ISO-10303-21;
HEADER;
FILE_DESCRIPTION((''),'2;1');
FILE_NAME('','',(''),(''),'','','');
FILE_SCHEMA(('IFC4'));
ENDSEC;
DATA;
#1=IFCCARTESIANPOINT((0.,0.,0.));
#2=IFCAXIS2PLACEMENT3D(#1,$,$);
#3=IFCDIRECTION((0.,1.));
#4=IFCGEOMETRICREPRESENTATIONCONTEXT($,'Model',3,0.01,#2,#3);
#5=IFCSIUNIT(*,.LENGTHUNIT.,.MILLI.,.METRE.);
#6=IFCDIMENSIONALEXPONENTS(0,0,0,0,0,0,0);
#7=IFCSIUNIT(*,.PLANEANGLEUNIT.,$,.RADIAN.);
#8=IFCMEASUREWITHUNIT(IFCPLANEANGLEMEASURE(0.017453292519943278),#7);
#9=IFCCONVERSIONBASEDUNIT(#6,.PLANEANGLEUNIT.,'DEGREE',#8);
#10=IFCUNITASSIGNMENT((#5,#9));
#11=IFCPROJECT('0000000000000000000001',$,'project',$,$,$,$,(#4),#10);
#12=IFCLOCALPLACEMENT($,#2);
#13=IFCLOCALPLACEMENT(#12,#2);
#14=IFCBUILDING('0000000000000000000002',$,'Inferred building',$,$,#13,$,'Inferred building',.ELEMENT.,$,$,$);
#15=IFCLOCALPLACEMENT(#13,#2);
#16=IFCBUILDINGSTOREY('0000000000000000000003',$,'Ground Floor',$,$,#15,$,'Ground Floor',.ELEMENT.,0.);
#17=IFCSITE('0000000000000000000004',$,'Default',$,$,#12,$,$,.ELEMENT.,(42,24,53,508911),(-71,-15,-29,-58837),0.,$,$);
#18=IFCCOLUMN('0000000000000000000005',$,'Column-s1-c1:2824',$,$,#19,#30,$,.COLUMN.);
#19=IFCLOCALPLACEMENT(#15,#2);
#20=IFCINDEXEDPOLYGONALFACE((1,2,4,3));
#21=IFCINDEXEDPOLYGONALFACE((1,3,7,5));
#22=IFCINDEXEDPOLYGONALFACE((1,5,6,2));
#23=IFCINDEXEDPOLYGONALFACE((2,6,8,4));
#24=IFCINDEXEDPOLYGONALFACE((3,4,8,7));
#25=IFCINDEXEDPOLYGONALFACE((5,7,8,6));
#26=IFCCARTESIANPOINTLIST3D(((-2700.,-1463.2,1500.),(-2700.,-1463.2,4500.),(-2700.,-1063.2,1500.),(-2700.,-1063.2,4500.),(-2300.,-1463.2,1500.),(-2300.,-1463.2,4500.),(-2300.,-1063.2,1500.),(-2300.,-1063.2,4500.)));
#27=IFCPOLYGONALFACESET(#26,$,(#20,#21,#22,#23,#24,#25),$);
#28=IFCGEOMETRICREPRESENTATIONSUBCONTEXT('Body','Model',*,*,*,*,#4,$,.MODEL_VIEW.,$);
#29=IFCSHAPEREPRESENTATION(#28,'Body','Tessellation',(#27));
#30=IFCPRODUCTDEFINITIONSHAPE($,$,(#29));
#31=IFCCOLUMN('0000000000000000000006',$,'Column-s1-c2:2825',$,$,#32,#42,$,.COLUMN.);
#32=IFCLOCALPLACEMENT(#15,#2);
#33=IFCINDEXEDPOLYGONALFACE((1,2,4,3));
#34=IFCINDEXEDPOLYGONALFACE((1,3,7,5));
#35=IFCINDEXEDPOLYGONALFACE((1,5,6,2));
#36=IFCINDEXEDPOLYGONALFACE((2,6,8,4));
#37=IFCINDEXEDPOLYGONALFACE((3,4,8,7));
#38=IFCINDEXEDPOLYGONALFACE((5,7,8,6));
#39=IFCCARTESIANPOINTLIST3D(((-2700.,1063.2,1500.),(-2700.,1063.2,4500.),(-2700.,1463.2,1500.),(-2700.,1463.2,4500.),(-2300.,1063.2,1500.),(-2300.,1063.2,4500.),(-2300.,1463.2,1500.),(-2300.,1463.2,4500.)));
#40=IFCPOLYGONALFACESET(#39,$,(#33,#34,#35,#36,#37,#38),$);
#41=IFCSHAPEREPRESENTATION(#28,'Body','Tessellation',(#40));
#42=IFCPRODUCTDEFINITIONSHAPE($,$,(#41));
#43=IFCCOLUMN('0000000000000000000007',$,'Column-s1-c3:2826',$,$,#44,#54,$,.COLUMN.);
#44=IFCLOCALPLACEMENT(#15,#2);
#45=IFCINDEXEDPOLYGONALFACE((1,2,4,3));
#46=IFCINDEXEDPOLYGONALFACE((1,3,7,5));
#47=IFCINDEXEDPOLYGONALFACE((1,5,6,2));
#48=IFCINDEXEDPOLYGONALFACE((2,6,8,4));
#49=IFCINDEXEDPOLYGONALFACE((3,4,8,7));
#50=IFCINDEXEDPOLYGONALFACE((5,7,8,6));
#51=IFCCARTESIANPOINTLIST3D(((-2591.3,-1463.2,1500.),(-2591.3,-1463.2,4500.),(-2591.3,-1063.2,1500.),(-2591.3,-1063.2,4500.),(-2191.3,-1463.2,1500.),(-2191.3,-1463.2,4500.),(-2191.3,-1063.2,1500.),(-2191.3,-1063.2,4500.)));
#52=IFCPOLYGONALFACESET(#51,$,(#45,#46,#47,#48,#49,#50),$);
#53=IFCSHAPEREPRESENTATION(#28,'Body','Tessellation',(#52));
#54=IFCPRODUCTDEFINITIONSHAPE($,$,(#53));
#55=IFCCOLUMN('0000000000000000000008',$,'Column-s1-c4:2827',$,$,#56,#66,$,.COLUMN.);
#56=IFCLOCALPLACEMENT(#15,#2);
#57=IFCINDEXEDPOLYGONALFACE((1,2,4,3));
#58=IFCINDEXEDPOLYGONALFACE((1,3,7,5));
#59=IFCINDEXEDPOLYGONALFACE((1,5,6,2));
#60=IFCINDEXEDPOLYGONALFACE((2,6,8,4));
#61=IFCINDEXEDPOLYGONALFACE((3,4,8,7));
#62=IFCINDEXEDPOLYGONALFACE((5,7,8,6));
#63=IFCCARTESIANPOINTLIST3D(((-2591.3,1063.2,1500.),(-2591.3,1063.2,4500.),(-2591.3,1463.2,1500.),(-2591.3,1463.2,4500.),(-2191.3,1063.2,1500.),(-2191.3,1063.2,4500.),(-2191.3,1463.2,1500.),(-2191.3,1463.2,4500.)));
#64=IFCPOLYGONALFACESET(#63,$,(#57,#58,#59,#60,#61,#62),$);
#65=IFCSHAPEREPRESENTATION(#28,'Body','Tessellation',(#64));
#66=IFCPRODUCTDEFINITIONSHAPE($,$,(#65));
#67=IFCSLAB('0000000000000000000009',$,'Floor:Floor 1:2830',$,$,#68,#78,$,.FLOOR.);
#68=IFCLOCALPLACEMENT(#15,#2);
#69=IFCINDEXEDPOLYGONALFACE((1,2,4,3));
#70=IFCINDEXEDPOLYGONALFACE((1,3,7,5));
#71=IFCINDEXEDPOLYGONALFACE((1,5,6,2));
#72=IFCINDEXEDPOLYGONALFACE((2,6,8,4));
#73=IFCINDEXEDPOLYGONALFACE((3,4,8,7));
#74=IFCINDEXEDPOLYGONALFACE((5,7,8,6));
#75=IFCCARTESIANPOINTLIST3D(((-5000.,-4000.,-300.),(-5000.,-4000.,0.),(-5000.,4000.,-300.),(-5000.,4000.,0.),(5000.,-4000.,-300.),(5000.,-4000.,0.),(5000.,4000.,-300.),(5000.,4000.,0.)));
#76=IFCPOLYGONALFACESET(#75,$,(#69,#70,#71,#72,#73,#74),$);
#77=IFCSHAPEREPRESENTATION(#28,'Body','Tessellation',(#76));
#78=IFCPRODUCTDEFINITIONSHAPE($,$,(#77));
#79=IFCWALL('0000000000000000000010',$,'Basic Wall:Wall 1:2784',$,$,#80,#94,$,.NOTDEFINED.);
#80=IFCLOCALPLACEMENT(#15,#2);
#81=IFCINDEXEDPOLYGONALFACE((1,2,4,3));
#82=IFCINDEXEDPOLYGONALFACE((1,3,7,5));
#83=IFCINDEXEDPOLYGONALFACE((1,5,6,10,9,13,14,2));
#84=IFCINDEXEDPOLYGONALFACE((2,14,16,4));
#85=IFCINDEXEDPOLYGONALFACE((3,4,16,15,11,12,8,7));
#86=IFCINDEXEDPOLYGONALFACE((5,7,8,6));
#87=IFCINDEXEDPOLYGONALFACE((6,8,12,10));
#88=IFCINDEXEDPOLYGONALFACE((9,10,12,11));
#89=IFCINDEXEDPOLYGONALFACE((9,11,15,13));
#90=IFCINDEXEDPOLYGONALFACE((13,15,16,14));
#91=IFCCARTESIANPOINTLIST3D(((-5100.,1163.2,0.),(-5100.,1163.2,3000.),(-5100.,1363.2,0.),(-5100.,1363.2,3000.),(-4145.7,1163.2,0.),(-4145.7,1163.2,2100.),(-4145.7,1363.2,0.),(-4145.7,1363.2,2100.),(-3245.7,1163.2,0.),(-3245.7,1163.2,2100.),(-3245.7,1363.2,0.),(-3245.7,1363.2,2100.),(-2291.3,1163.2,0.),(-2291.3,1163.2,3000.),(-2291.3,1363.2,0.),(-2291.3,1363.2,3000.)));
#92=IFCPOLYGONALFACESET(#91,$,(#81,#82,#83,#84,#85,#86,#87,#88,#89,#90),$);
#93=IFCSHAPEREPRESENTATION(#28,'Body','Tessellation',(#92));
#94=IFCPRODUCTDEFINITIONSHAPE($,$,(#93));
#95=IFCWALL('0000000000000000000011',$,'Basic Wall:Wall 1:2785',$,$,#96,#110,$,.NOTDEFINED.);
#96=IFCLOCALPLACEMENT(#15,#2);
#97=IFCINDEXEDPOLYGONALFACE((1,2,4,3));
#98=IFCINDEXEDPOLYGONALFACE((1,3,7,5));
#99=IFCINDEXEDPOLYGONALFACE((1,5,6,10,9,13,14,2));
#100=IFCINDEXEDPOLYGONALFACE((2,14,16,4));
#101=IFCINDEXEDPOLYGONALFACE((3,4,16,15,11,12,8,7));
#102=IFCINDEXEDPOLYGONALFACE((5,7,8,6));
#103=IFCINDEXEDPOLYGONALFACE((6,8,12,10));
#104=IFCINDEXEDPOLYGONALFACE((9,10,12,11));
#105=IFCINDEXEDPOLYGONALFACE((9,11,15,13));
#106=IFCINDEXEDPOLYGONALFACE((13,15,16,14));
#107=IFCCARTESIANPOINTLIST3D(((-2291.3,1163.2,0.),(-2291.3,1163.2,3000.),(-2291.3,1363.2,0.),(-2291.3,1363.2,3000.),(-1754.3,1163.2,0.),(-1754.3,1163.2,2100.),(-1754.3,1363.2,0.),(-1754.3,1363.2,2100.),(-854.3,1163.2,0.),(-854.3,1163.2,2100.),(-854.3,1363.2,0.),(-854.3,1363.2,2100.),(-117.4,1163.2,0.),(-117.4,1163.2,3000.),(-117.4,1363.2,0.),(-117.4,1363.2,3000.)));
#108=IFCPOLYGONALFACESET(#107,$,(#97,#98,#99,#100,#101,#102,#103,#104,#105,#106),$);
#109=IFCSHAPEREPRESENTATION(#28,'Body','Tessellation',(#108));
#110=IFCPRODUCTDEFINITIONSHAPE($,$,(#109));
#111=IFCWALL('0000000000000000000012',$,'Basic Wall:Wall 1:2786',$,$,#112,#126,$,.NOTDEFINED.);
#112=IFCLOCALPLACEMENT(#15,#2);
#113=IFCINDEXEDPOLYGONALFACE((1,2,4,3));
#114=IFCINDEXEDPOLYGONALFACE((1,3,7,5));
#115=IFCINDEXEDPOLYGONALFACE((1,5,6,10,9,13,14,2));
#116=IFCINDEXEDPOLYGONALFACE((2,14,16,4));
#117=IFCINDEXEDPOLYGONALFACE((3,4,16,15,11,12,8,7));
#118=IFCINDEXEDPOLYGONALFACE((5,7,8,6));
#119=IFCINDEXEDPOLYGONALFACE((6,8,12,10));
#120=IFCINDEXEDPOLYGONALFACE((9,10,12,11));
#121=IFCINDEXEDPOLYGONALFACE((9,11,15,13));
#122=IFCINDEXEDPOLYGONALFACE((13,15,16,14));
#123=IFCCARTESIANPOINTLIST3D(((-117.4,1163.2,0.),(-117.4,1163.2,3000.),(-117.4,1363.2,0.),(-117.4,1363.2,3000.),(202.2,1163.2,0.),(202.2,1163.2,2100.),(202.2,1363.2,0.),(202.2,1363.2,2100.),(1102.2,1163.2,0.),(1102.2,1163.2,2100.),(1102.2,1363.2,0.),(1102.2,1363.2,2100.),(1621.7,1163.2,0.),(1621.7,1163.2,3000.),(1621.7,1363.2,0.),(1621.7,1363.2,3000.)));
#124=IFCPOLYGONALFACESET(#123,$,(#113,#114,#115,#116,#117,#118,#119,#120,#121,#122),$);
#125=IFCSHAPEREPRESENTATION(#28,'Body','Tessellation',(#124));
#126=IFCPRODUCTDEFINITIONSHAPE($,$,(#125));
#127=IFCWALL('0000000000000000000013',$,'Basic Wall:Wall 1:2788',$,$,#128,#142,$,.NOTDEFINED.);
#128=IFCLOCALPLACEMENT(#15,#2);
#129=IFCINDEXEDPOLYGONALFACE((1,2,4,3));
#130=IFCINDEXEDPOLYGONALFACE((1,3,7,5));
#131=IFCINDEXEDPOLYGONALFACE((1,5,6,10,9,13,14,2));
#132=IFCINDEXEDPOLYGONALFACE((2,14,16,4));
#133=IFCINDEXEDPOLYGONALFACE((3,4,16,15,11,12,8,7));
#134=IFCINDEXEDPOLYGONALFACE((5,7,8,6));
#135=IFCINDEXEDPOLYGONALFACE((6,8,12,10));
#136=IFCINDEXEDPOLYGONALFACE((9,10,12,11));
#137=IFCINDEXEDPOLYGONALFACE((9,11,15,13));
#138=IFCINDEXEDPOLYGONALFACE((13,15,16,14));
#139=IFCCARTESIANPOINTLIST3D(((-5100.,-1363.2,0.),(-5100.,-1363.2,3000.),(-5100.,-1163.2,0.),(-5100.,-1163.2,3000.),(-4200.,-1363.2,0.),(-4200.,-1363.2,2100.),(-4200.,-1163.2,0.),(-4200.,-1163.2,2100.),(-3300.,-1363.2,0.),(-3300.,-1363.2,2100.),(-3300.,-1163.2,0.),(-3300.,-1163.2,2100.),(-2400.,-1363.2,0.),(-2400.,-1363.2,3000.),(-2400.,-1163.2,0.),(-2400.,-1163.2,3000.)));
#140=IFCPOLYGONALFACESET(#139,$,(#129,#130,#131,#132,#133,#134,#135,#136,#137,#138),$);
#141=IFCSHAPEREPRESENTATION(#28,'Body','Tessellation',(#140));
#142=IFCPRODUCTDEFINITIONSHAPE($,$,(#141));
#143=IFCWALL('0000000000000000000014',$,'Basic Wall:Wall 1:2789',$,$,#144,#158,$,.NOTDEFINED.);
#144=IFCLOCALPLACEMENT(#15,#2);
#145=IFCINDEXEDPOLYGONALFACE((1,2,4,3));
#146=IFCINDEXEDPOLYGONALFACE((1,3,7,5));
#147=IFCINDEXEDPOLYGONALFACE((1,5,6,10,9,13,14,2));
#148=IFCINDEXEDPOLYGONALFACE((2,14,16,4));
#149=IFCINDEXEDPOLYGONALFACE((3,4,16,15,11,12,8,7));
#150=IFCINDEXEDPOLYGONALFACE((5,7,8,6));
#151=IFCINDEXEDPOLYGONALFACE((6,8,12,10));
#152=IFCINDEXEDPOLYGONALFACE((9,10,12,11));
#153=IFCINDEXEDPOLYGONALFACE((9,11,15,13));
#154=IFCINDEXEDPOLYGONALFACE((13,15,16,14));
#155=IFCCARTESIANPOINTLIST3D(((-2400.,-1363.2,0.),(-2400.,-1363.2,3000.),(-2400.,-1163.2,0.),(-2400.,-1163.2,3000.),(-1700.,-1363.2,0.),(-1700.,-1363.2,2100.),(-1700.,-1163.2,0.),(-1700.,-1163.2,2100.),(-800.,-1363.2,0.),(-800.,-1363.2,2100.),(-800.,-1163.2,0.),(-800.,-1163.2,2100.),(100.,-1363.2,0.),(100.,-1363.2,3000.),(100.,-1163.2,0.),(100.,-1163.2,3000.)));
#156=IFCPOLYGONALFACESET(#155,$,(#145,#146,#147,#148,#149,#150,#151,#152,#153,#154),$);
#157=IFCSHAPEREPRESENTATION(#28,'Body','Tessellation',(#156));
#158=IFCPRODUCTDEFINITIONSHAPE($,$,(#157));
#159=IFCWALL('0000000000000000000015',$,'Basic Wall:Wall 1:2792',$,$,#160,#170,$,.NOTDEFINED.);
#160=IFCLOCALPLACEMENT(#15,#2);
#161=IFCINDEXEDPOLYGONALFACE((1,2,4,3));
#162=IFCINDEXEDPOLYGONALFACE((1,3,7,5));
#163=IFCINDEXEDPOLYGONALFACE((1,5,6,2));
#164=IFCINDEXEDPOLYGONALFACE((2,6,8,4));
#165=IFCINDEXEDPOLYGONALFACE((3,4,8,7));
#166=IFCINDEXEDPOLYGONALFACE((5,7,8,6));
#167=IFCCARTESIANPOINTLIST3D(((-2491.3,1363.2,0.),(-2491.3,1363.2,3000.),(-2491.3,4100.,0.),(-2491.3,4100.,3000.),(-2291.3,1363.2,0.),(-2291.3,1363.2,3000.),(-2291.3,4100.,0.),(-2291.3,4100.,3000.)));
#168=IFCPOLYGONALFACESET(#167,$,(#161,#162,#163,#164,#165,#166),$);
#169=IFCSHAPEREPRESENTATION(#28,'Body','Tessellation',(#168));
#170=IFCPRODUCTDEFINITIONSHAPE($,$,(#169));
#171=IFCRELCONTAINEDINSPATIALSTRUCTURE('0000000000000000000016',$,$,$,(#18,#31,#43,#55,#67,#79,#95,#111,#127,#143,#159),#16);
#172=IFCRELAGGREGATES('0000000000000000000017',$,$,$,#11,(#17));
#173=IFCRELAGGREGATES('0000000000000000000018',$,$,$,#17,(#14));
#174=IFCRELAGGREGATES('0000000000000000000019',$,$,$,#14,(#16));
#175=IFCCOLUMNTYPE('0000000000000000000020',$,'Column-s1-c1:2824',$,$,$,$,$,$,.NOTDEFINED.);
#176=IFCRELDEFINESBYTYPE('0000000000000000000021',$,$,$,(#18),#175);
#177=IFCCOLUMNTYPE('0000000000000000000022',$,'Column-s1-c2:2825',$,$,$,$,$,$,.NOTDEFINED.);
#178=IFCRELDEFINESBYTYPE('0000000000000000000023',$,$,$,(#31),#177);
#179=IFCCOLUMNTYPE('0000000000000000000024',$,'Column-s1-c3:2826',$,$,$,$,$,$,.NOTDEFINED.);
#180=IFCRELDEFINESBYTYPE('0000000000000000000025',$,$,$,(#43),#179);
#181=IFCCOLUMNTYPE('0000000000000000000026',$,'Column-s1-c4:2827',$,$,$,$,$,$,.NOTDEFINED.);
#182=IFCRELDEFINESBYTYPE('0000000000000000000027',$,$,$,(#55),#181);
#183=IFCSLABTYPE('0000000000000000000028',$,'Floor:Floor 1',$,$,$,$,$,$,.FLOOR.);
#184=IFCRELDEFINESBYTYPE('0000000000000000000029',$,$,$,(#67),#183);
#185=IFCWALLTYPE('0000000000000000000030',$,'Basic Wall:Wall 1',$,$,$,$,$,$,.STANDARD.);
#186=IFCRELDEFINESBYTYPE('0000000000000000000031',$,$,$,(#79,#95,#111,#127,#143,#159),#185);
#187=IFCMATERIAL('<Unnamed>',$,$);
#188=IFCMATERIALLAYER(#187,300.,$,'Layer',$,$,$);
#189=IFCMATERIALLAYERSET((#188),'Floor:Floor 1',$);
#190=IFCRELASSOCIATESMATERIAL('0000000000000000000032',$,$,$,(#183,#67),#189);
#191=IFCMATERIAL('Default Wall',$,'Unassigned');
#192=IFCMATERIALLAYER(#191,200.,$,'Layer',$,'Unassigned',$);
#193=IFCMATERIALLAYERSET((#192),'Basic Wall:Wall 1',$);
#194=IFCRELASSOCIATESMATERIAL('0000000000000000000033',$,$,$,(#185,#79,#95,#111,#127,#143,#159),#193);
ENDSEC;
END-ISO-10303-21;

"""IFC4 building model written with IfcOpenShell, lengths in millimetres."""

from ifc_helpers import new_model, entity, si_unit, converted_unit, direction, frame, frame_2d, origin, origin_2d_with_axis, place, context, subcontext, project, spatial, rectangle, extrude, material, layer, layer_set, layer_usage, type_object, element, save


model = new_model("IFC4")

# Units and contexts
model_context = context("Model", 3, precision=0.01, world=origin(), true_north=direction((0.0, 1.0)))
body_context = subcontext(model_context, "Body", "Model", "MODEL_VIEW")
ifc_project = project(units=[si_unit("LENGTHUNIT", "METRE", prefix="MILLI"), converted_unit("PLANEANGLEUNIT", "DEGREE", entity("IfcPlaneAngleMeasure", 0.017453292519943278), si_unit("PLANEANGLEUNIT", "RADIAN"), dimensions=[0, 0, 0, 0, 0, 0, 0])], contexts=[model_context])

# Site, building, storey
site_placement = place(None, origin())
site = spatial("IfcSite", under=ifc_project, at=site_placement, Name="Default", CompositionType="ELEMENT", RefLatitude=(42, 24, 53, 508911), RefLongitude=(-71, -15, -29, -58837), RefElevation=0.0)
building_placement = place(site_placement, origin())
building = spatial("IfcBuilding", under=site, at=building_placement, Name="Inferred building", LongName="Inferred building", CompositionType="ELEMENT")
storey_placement = place(building_placement, origin())
storey = spatial("IfcBuildingStorey", under=building, at=storey_placement, Name="Ground Floor", LongName="Ground Floor", CompositionType="ELEMENT", Elevation=0.0)

# Columns
column_type_1 = type_object("IfcColumnType", Name="Column-s1-c1:2824", PredefinedType="NOTDEFINED")
column_1_placement = place(storey_placement, origin())
element("IfcColumn", 1, at=column_1_placement, inside=storey, type_object=column_type_1, Name="Column-s1-c1:2824", PredefinedType="COLUMN", context=body_context, shape_type="SweptSolid", body=[
    extrude(rectangle(XDim=400.0, YDim=400.0, at=origin_2d_with_axis()), frame((-2500.0, -1263.2, 1500.0)), (0.0, 0.0, 1.0), 3000.0),
])
column_type_2 = type_object("IfcColumnType", Name="Column-s1-c2:2825", PredefinedType="NOTDEFINED")
column_2_placement = place(storey_placement, origin())
element("IfcColumn", 2, at=column_2_placement, inside=storey, type_object=column_type_2, Name="Column-s1-c2:2825", PredefinedType="COLUMN", context=body_context, shape_type="SweptSolid", body=[
    extrude(rectangle(XDim=400.0, YDim=400.0, at=origin_2d_with_axis()), frame((-2500.0, 1263.2, 1500.0)), (0.0, 0.0, 1.0), 3000.0),
])
column_type_3 = type_object("IfcColumnType", Name="Column-s1-c3:2826", PredefinedType="NOTDEFINED")
column_3_placement = place(storey_placement, origin())
element("IfcColumn", 3, at=column_3_placement, inside=storey, type_object=column_type_3, Name="Column-s1-c3:2826", PredefinedType="COLUMN", context=body_context, shape_type="SweptSolid", body=[
    extrude(rectangle(XDim=400.0, YDim=400.0, at=origin_2d_with_axis()), frame((-2391.3, -1263.2, 1500.0)), (0.0, 0.0, 1.0), 3000.0),
])
column_type_4 = type_object("IfcColumnType", Name="Column-s1-c4:2827", PredefinedType="NOTDEFINED")
column_4_placement = place(storey_placement, origin())
element("IfcColumn", 4, at=column_4_placement, inside=storey, type_object=column_type_4, Name="Column-s1-c4:2827", PredefinedType="COLUMN", context=body_context, shape_type="SweptSolid", body=[
    extrude(rectangle(XDim=400.0, YDim=400.0, at=origin_2d_with_axis()), frame((-2391.3, 1263.2, 1500.0)), (0.0, 0.0, 1.0), 3000.0),
])

# Slab
ifc_material_1 = material(Name="<Unnamed>")
ifc_layer_1 = layer(ifc_material_1, 300.0, Name="Layer")
ifc_layer_set_1 = layer_set([ifc_layer_1], Name="Floor:Floor 1")
ifc_layer_usage_1 = layer_usage(ifc_layer_set_1, "AXIS3", "POSITIVE", 0.0)
slab_type = type_object("IfcSlabType", Name="Floor:Floor 1", PredefinedType="FLOOR", material=ifc_layer_set_1)
slab_placement = place(storey_placement, origin())
element("IfcSlab", 5, at=slab_placement, inside=storey, type_object=slab_type, material=ifc_layer_usage_1, Name="Floor:Floor 1:2830", PredefinedType="FLOOR", context=body_context, shape_type="SweptSolid", body=[
    extrude(rectangle(XDim=8000.0, YDim=10000.0, at=origin_2d_with_axis()), frame((0.0, 0.0, 0.0), z_axis=(0.0, 0.0, -1.0), x_axis=(0.0, 1.0, 0.0)), (0.0, 0.0, 1.0), 300.0),
])

# Walls, openings
ifc_material_2 = material(Name="Default Wall", Category="Unassigned")
ifc_layer_2 = layer(ifc_material_2, 200.0, Name="Layer", Category="Unassigned")
ifc_layer_set_2 = layer_set([ifc_layer_2], Name="Basic Wall:Wall 1")
ifc_layer_usage_2 = layer_usage(ifc_layer_set_2, "AXIS2", "NEGATIVE", 100.0)
wall_type = type_object("IfcWallType", Name="Basic Wall:Wall 1", PredefinedType="STANDARD", material=ifc_layer_set_2)
wall_1_placement = place(storey_placement, frame((-5100.0, 1263.2, 0.0)))
wall_1 = element("IfcWall", 6, at=wall_1_placement, inside=storey, type_object=wall_type, material=ifc_layer_usage_2, Name="Basic Wall:Wall 1:2784", PredefinedType="NOTDEFINED", context=body_context, shape_type="SweptSolid", body=[
    extrude(rectangle(XDim=2808.7, YDim=200.0, at=frame_2d((1404.3, 0.0), x_axis=(1.0, 0.0))), origin(), (0.0, 0.0, 1.0), 3000.0),
])
opening_1_placement = place(wall_1_placement, origin())
element("IfcOpeningElement", 7, at=opening_1_placement, cuts=wall_1, PredefinedType="OPENING", context=body_context, shape_type="SweptSolid", body=[
    extrude(rectangle(XDim=2100.0, YDim=900.0, at=origin_2d_with_axis()), frame((1404.3, -100.0, 1050.0), z_axis=(0.0, 1.0, 0.0), x_axis=(0.0, 0.0, -1.0)), (0.0, 0.0, 1.0), 200.0),
])
ifc_layer_usage_3 = layer_usage(ifc_layer_set_2, "AXIS2", "NEGATIVE", 100.0)
wall_2_placement = place(storey_placement, frame((-2291.3, 1263.2, 0.0)))
wall_2 = element("IfcWall", 8, at=wall_2_placement, inside=storey, type_object=wall_type, material=ifc_layer_usage_3, Name="Basic Wall:Wall 1:2785", PredefinedType="NOTDEFINED", context=body_context, shape_type="SweptSolid", body=[
    extrude(rectangle(XDim=2173.9, YDim=200.0, at=frame_2d((1087.0, 0.0), x_axis=(1.0, 0.0))), origin(), (0.0, 0.0, 1.0), 3000.0),
])
opening_2_placement = place(wall_2_placement, origin())
element("IfcOpeningElement", 9, at=opening_2_placement, cuts=wall_2, PredefinedType="OPENING", context=body_context, shape_type="SweptSolid", body=[
    extrude(rectangle(XDim=2100.0, YDim=900.0, at=origin_2d_with_axis()), frame((987.0, -100.0, 1050.0), z_axis=(0.0, 1.0, 0.0), x_axis=(0.0, 0.0, -1.0)), (0.0, 0.0, 1.0), 200.0),
])
ifc_layer_usage_4 = layer_usage(ifc_layer_set_2, "AXIS2", "NEGATIVE", 100.0)
wall_3_placement = place(storey_placement, frame((-117.4, 1263.2, 0.0)))
wall_3 = element("IfcWall", 10, at=wall_3_placement, inside=storey, type_object=wall_type, material=ifc_layer_usage_4, Name="Basic Wall:Wall 1:2786", PredefinedType="NOTDEFINED", context=body_context, shape_type="SweptSolid", body=[
    extrude(rectangle(XDim=1739.1, YDim=200.0, at=frame_2d((869.6, 0.0), x_axis=(1.0, 0.0))), origin(), (0.0, 0.0, 1.0), 3000.0),
])
opening_3_placement = place(wall_3_placement, origin())
element("IfcOpeningElement", 11, at=opening_3_placement, cuts=wall_3, PredefinedType="OPENING", context=body_context, shape_type="SweptSolid", body=[
    extrude(rectangle(XDim=2100.0, YDim=900.0, at=frame_2d((0.0, 0.0), x_axis=(1.0, 0.0))), frame((769.6, -100.0, 1050.0), z_axis=(0.0, 1.0, 0.0), x_axis=(0.0, 0.0, -1.0)), (0.0, 0.0, 1.0), 200.0),
])
ifc_layer_usage_5 = layer_usage(ifc_layer_set_2, "AXIS2", "NEGATIVE", 100.0)
wall_4_placement = place(storey_placement, frame((-5100.0, -1263.2, 0.0)))
wall_4 = element("IfcWall", 12, at=wall_4_placement, inside=storey, type_object=wall_type, material=ifc_layer_usage_5, Name="Basic Wall:Wall 1:2788", PredefinedType="NOTDEFINED", context=body_context, shape_type="SweptSolid", body=[
    extrude(rectangle(XDim=2700.0, YDim=200.0, at=frame_2d((1350.0, 0.0), x_axis=(1.0, 0.0))), origin(), (0.0, 0.0, 1.0), 3000.0),
])
opening_4_placement = place(wall_4_placement, origin())
element("IfcOpeningElement", 13, at=opening_4_placement, cuts=wall_4, PredefinedType="OPENING", context=body_context, shape_type="SweptSolid", body=[
    extrude(rectangle(XDim=2100.0, YDim=900.0, at=frame_2d((0.0, 0.0), x_axis=(1.0, 0.0))), frame((1350.0, -100.0, 1050.0), z_axis=(0.0, 1.0, 0.0), x_axis=(0.0, 0.0, -1.0)), (0.0, 0.0, 1.0), 200.0),
])
ifc_layer_usage_6 = layer_usage(ifc_layer_set_2, "AXIS2", "NEGATIVE", 100.0)
wall_5_placement = place(storey_placement, frame((-2400.0, -1263.2, 0.0)))
wall_5 = element("IfcWall", 14, at=wall_5_placement, inside=storey, type_object=wall_type, material=ifc_layer_usage_6, Name="Basic Wall:Wall 1:2789", PredefinedType="NOTDEFINED", context=body_context, shape_type="SweptSolid", body=[
    extrude(rectangle(XDim=2500.0, YDim=200.0, at=frame_2d((1250.0, 0.0), x_axis=(1.0, 0.0))), origin(), (0.0, 0.0, 1.0), 3000.0),
])
opening_5_placement = place(wall_5_placement, origin())
element("IfcOpeningElement", 15, at=opening_5_placement, cuts=wall_5, PredefinedType="OPENING", context=body_context, shape_type="SweptSolid", body=[
    extrude(rectangle(XDim=2100.0, YDim=900.0, at=origin_2d_with_axis()), frame((1150.0, -100.0, 1050.0), z_axis=(0.0, 1.0, 0.0), x_axis=(0.0, 0.0, -1.0)), (0.0, 0.0, 1.0), 200.0),
])

# Wall
ifc_layer_usage_7 = layer_usage(ifc_layer_set_2, "AXIS2", "NEGATIVE", 100.0)
wall_6_placement = place(storey_placement, frame((-2391.3, 1363.2, 0.0), z_axis=(0.0, 0.0, 1.0), x_axis=(0.0, 1.0, 0.0)))
element("IfcWall", 16, at=wall_6_placement, inside=storey, type_object=wall_type, material=ifc_layer_usage_7, Name="Basic Wall:Wall 1:2792", PredefinedType="NOTDEFINED", context=body_context, shape_type="SweptSolid", body=[
    extrude(rectangle(XDim=2736.8, YDim=200.0, at=frame_2d((1368.4, 0.0), x_axis=(-1.0, 0.0))), origin(), (0.0, 0.0, 1.0), 3000.0),
])

save(model, "model.ifc")
